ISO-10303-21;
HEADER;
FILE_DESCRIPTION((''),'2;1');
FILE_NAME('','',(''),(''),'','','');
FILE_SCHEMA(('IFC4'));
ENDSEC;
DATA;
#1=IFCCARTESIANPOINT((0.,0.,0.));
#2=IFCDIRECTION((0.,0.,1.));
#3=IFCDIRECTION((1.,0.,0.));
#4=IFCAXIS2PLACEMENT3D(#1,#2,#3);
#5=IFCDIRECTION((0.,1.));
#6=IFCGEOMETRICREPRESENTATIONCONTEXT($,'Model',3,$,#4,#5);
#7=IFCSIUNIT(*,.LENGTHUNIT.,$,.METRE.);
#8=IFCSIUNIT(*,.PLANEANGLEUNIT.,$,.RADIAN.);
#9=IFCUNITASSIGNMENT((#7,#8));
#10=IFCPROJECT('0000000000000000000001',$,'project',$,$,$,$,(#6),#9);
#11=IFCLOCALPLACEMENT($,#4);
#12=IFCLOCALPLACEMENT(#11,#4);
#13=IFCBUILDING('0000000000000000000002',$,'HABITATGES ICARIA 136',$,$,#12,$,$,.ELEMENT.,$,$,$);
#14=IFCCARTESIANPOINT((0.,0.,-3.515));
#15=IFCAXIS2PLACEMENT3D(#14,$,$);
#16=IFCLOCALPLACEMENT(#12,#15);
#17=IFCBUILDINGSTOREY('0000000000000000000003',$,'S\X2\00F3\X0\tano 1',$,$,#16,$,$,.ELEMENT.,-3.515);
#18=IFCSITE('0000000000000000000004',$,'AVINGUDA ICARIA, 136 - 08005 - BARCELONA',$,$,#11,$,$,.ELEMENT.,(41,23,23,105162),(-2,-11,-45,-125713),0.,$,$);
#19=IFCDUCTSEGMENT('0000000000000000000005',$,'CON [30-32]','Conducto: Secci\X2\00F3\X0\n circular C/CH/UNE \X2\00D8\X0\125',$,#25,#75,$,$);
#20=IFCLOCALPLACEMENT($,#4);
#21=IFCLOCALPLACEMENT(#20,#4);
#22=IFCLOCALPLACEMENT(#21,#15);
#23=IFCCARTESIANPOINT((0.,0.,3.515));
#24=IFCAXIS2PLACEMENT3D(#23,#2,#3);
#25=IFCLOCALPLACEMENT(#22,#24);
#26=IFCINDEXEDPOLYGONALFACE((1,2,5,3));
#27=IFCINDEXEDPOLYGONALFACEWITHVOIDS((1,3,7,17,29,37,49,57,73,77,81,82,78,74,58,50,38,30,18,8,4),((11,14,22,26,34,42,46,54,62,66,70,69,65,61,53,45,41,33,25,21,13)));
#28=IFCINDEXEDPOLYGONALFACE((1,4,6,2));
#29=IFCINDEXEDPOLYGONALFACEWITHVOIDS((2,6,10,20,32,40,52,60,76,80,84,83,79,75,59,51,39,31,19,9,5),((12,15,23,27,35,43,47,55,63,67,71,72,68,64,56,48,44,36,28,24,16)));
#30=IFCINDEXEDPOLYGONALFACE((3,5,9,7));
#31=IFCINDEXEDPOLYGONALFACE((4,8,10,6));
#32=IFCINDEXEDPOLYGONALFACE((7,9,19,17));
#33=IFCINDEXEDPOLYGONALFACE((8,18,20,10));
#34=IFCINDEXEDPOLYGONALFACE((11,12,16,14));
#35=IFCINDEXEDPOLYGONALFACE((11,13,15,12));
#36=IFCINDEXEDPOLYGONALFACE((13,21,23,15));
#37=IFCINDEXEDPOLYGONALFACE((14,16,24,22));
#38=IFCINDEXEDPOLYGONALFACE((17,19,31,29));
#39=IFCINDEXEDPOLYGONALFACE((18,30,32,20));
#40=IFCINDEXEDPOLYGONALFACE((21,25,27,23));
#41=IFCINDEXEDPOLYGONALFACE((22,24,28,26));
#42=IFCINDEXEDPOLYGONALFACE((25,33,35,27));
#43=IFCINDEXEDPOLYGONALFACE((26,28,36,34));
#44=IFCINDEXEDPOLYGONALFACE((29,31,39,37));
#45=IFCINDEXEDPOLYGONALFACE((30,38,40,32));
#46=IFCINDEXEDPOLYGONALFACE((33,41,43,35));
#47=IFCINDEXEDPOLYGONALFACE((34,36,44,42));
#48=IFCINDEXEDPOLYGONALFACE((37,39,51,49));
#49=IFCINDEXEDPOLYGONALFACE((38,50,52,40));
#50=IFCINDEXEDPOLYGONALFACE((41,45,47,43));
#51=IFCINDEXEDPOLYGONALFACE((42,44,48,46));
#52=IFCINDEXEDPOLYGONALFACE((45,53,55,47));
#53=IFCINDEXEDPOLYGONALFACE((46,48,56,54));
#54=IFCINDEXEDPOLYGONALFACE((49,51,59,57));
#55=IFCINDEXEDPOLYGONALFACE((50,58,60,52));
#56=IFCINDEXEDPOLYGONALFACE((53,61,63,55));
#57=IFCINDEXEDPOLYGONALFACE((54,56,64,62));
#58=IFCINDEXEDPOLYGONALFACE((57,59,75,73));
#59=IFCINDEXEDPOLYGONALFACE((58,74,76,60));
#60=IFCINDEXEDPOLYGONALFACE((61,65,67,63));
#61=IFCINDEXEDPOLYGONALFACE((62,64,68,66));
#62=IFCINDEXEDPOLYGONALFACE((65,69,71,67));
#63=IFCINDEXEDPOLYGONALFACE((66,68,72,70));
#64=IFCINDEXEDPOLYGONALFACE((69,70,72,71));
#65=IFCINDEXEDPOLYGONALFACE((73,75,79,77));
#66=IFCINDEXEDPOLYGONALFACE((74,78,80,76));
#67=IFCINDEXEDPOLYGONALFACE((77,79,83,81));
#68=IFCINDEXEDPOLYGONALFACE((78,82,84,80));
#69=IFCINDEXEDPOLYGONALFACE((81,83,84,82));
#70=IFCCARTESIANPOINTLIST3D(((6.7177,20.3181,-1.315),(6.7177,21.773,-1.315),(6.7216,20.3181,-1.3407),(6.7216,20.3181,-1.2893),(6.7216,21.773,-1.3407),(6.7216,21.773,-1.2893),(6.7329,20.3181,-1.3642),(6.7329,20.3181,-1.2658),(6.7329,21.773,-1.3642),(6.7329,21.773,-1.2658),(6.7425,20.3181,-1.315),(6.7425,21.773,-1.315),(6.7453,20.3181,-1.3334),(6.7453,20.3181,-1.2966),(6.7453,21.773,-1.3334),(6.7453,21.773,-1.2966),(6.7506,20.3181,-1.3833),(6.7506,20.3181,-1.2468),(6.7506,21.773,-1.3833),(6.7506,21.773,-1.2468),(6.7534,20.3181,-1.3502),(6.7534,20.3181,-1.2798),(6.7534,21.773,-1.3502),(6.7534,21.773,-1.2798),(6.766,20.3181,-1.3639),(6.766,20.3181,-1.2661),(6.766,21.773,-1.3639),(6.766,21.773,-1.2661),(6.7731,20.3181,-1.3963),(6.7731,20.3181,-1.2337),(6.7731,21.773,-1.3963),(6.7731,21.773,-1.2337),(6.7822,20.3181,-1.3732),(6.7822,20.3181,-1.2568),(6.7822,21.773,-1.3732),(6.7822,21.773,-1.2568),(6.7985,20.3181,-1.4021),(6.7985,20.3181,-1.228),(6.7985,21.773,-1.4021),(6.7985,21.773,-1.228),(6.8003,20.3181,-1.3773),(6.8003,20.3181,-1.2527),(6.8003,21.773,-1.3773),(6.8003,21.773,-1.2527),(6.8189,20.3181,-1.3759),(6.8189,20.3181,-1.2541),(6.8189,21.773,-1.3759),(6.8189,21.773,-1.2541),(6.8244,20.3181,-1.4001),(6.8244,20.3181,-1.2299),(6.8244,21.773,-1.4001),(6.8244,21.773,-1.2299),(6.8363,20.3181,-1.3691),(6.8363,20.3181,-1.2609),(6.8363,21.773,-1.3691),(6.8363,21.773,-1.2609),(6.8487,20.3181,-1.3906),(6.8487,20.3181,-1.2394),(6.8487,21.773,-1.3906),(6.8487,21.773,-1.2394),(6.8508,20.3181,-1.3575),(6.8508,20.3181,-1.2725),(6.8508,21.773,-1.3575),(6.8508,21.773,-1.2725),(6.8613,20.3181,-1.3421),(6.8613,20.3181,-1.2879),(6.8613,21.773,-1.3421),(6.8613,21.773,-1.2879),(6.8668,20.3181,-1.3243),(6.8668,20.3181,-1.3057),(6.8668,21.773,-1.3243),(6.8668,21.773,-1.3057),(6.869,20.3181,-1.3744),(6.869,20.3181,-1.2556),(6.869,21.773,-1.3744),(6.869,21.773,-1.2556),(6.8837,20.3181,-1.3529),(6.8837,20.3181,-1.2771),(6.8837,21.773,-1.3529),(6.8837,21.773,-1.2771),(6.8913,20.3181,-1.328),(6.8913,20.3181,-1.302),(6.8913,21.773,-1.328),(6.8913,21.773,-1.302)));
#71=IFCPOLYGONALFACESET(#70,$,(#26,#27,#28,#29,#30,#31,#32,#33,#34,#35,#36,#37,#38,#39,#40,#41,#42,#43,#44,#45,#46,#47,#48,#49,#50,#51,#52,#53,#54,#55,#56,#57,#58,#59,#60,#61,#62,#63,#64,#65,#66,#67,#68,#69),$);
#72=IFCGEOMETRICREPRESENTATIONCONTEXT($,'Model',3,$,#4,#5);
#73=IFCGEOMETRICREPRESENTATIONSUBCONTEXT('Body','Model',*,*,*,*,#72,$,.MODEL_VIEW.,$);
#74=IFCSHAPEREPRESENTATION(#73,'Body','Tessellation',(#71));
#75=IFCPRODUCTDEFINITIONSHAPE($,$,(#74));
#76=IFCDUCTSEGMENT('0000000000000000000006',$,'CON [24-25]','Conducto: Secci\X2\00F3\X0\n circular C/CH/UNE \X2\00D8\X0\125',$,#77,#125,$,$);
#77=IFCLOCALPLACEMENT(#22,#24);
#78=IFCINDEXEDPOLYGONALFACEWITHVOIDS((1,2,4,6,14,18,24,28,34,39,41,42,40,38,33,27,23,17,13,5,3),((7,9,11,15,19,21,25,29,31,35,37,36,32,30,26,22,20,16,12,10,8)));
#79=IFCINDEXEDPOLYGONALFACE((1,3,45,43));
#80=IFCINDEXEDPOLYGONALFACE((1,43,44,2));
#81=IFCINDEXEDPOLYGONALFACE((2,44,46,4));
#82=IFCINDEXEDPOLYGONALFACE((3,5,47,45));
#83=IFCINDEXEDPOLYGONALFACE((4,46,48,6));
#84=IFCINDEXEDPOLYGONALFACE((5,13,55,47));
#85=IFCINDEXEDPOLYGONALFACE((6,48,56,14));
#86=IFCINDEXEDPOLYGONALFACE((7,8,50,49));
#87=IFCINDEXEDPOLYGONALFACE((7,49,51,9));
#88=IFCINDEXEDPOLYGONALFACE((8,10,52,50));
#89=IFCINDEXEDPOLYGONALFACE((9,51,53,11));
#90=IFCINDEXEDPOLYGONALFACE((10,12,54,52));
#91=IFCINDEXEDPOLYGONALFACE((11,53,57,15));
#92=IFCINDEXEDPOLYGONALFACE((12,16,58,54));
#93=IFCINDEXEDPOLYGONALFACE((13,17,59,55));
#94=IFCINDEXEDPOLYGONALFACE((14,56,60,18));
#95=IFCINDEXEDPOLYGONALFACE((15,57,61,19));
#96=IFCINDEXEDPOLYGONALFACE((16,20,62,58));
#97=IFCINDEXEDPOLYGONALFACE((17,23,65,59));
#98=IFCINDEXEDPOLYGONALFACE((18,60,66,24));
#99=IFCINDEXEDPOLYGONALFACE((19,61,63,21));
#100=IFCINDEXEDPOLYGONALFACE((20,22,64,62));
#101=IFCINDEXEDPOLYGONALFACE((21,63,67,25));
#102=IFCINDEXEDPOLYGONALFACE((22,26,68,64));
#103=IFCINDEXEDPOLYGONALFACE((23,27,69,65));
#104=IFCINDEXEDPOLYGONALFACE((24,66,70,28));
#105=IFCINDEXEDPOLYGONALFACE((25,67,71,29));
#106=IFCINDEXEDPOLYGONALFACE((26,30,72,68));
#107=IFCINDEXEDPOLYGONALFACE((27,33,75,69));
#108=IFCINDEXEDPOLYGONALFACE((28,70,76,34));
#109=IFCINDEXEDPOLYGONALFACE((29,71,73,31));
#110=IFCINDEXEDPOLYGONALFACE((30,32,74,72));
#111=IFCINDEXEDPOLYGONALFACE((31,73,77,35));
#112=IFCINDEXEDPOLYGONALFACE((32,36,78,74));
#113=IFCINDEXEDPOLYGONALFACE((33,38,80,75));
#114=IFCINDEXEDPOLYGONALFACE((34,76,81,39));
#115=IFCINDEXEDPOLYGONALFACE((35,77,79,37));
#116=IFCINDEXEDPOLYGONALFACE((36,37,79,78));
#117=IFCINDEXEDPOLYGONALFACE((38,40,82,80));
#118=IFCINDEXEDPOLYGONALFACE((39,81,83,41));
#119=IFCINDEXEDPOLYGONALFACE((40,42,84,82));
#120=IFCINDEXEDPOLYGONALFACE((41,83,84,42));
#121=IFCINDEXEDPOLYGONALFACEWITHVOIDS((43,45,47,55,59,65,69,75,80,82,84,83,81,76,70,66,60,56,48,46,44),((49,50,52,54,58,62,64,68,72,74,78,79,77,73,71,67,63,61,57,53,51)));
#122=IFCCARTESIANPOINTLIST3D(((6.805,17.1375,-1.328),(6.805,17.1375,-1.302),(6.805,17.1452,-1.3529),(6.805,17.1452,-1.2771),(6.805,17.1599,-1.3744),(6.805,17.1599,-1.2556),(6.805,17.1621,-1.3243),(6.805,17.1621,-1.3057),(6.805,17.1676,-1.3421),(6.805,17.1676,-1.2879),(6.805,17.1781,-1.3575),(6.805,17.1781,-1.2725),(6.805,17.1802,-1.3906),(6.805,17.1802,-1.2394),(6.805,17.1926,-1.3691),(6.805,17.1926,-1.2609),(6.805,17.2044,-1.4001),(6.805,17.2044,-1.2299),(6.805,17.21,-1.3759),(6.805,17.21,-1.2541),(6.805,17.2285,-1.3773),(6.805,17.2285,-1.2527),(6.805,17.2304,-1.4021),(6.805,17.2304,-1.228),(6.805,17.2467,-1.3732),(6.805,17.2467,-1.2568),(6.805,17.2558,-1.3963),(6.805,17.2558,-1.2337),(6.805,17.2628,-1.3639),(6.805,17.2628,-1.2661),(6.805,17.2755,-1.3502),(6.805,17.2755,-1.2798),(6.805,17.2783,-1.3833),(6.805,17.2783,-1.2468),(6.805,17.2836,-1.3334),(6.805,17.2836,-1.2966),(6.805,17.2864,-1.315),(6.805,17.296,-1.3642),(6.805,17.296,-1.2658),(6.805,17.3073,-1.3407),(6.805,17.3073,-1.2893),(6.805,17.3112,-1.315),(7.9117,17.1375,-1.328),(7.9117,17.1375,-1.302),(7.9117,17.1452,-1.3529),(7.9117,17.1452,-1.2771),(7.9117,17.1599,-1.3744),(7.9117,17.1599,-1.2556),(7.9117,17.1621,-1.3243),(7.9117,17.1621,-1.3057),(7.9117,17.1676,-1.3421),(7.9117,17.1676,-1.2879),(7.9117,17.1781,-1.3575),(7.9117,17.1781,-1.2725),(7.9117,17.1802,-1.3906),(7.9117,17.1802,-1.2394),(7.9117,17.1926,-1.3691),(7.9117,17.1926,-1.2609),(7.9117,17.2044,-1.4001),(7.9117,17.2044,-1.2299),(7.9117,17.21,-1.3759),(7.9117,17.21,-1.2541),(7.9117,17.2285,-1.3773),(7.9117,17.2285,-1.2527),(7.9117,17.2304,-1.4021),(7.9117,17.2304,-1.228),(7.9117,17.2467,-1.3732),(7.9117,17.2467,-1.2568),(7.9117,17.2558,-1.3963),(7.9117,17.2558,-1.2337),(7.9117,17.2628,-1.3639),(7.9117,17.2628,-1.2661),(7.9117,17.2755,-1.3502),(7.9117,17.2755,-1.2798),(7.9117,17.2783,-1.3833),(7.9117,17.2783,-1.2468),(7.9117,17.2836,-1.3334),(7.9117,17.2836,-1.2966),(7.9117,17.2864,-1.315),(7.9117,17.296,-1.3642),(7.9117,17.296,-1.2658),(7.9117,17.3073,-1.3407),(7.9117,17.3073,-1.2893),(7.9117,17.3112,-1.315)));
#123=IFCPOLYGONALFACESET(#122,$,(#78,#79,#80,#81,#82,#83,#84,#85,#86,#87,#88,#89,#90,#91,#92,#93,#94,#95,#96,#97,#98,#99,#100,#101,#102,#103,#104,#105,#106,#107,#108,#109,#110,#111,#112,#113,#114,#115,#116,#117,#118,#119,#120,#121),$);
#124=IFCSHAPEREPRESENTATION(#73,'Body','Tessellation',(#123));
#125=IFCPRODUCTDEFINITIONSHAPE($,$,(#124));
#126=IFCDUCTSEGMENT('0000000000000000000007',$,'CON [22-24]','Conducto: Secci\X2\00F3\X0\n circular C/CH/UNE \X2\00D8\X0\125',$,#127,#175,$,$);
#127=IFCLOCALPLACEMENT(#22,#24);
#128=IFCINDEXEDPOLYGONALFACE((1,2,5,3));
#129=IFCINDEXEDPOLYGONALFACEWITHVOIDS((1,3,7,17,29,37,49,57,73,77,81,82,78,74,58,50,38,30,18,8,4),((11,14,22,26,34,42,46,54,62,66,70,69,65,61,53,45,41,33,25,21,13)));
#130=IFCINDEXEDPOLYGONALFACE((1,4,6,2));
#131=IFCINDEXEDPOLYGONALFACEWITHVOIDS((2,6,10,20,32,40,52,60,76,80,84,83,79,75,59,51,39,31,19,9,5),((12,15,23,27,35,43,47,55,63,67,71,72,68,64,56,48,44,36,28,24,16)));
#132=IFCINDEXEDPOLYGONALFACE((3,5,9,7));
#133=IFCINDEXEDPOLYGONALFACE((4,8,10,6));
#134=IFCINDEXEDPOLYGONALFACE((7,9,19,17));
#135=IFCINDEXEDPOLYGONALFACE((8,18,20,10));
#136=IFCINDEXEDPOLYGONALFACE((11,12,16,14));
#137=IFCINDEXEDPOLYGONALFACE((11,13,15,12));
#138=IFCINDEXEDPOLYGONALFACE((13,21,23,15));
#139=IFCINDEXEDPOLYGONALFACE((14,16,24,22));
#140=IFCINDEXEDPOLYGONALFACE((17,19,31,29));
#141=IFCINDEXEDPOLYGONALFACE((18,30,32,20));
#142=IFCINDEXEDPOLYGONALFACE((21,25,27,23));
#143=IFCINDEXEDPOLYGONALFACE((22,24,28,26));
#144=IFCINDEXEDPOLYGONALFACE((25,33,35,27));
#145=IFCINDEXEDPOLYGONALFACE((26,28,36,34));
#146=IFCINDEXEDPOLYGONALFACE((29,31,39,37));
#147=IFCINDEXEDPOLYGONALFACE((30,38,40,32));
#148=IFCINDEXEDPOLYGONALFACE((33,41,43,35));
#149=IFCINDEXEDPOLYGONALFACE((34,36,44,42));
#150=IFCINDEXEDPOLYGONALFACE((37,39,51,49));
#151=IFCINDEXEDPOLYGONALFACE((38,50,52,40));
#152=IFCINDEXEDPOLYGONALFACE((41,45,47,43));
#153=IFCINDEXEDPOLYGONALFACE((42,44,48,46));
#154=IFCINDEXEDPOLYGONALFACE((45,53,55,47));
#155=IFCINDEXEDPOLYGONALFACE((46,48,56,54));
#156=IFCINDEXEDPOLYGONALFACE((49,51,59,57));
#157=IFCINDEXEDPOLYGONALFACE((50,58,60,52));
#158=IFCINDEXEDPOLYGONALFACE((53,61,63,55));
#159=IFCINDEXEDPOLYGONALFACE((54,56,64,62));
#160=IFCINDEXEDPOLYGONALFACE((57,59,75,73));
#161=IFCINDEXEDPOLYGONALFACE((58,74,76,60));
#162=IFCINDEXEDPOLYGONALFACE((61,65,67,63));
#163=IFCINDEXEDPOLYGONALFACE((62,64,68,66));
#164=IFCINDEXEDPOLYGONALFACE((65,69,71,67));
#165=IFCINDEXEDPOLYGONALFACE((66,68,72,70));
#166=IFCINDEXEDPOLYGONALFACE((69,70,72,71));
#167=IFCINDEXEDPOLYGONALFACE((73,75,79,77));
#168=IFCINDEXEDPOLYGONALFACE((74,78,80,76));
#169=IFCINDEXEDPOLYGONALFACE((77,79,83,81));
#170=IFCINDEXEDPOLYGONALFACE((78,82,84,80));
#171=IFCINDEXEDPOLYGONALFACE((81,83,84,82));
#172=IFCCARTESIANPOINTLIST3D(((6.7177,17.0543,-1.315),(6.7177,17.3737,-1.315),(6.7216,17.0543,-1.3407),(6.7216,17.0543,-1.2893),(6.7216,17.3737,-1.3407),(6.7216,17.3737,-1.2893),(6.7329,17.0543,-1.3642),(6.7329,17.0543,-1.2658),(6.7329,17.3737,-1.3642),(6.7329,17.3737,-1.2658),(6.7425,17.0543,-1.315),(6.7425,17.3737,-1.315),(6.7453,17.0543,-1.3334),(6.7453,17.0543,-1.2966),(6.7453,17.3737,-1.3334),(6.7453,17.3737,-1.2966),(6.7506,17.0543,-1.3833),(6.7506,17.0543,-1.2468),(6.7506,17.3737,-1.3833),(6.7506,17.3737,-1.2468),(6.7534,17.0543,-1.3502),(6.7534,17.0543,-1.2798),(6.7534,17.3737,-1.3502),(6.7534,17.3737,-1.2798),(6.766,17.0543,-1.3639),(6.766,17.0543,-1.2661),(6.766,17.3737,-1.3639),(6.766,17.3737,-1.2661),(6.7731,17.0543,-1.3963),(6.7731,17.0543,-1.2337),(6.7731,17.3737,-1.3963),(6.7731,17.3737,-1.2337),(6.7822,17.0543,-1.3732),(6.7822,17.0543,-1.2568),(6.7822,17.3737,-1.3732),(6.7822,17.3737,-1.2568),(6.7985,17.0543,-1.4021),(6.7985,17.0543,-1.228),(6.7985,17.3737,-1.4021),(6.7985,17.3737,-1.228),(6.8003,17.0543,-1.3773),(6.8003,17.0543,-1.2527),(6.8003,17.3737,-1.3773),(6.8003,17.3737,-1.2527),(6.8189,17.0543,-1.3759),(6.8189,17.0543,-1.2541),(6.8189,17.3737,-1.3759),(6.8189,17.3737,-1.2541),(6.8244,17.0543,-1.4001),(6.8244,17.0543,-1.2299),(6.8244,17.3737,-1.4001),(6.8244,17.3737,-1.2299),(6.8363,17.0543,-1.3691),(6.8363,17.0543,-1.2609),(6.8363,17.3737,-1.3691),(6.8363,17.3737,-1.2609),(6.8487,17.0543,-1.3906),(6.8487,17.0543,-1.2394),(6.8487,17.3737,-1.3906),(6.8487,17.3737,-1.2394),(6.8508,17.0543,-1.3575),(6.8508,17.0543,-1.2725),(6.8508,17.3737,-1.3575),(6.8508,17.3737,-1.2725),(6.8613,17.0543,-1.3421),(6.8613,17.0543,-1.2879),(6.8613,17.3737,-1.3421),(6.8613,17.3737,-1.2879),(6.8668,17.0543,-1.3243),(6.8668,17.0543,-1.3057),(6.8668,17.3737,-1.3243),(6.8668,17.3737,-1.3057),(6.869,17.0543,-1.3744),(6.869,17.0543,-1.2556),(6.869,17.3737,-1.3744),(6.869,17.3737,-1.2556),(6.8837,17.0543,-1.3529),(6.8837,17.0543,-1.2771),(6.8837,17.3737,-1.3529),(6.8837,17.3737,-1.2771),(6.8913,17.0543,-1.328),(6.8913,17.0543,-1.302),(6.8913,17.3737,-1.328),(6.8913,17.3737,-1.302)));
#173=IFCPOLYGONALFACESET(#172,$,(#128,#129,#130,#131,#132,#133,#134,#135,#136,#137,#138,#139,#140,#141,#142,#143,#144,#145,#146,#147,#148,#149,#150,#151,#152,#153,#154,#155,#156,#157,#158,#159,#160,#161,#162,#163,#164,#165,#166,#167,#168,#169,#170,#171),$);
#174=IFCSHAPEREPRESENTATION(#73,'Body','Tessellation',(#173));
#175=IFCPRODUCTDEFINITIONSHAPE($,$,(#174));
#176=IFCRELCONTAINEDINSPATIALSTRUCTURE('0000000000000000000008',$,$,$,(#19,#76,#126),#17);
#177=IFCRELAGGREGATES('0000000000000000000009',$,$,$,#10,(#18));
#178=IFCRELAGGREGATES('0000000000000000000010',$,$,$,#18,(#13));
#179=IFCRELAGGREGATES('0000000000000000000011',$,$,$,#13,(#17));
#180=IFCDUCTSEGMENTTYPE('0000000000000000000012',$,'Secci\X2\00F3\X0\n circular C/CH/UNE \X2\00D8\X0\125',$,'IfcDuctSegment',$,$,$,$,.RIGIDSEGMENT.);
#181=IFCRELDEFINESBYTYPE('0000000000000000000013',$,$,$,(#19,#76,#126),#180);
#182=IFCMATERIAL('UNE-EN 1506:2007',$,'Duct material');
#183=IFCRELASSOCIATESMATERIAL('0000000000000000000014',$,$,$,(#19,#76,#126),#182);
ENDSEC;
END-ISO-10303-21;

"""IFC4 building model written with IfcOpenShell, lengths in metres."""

from ifc_helpers import new_model, si_unit, direction, frame, origin_with_axes, origin_2d_with_axis, place, context, subcontext, project, spatial, hollow_circle, extrude, material, type_object, element, save


model = new_model("IFC4")

# Units and contexts
model_context_1 = context("Model", 3, world=origin_with_axes(), true_north=direction((0.0, 1.0)))
model_context_2 = context("Model", 3, world=origin_with_axes(), true_north=direction((0.0, 1.0)))
body_context_1 = subcontext(model_context_2, "Body", "Model", "MODEL_VIEW")
ifc_project = project(units=[si_unit("LENGTHUNIT", "METRE"), si_unit("PLANEANGLEUNIT", "RADIAN")], contexts=[model_context_1])

# Site, building, storey
site_placement = place(None, origin_with_axes())
site = spatial("IfcSite", under=ifc_project, at=site_placement, Name="AVINGUDA ICARIA, 136 - 08005 - BARCELONA", CompositionType="ELEMENT", RefLatitude=(41, 23, 23, 105162), RefLongitude=(-2, -11, -45, -125713), RefElevation=0.0)
building_placement = place(site_placement, origin_with_axes())
building = spatial("IfcBuilding", under=site, at=building_placement, Name="HABITATGES ICARIA 136", CompositionType="ELEMENT")
storey_placement = place(building_placement, frame((0.0, 0.0, -3.515)))
storey = spatial("IfcBuildingStorey", under=building, at=storey_placement, Name="Sótano 1", CompositionType="ELEMENT", Elevation=-3.515)

# Duct segments
ifc_material_1 = material(Name="UNE-EN 1506:2007", Category="Duct material")
duct_segment_type = type_object("IfcDuctSegmentType", Name="Sección circular C/CH/UNE Ø125", ApplicableOccurrence="IfcDuctSegment", PredefinedType="RIGIDSEGMENT")
placement_1 = place(None, origin_with_axes())
placement_2 = place(placement_1, origin_with_axes())
placement_3 = place(placement_2, frame((0.0, 0.0, -3.515)))
duct_segment_1_placement = place(placement_3, frame((0.0, 0.0, 3.515), z_axis=(0.0, 0.0, 1.0), x_axis=(1.0, 0.0, 0.0)))
element("IfcDuctSegment", 1, at=duct_segment_1_placement, inside=storey, type_object=duct_segment_type, material=ifc_material_1, Name="CON [30-32]", Description="Conducto: Sección circular C/CH/UNE Ø125", context=body_context_1, shape_type="SweptSolid", body=[
    extrude(hollow_circle(Radius=0.0873, WallThickness=0.0248, at=origin_2d_with_axis()), frame((6.805, 20.3181, -1.315), z_axis=(0.0, 1.0, 0.0), x_axis=(-1.0, 0.0, 0.0)), (0.0, 0.0, 1.0), 1.4549),
])
duct_segment_2_placement = place(placement_3, frame((0.0, 0.0, 3.515), z_axis=(0.0, 0.0, 1.0), x_axis=(1.0, 0.0, 0.0)))
element("IfcDuctSegment", 2, at=duct_segment_2_placement, inside=storey, type_object=duct_segment_type, material=ifc_material_1, Name="CON [24-25]", Description="Conducto: Sección circular C/CH/UNE Ø125", context=body_context_1, shape_type="SweptSolid", body=[
    extrude(hollow_circle(Radius=0.0873, WallThickness=0.0248, at=origin_2d_with_axis()), frame((6.805, 17.2239, -1.315), z_axis=(1.0, 0.0, 0.0), x_axis=(0.0, 1.0, 0.0)), (0.0, 0.0, 1.0), 1.1067),
])
duct_segment_3_placement = place(placement_3, frame((0.0, 0.0, 3.515), z_axis=(0.0, 0.0, 1.0), x_axis=(1.0, 0.0, 0.0)))
element("IfcDuctSegment", 3, at=duct_segment_3_placement, inside=storey, type_object=duct_segment_type, material=ifc_material_1, Name="CON [22-24]", Description="Conducto: Sección circular C/CH/UNE Ø125", context=body_context_1, shape_type="SweptSolid", body=[
    extrude(hollow_circle(Radius=0.0873, WallThickness=0.0248, at=origin_2d_with_axis()), frame((6.805, 17.0543, -1.315), z_axis=(0.0, 1.0, 0.0), x_axis=(-1.0, 0.0, 0.0)), (0.0, 0.0, 1.0), 0.3194),
])

save(model, "model.ifc")
